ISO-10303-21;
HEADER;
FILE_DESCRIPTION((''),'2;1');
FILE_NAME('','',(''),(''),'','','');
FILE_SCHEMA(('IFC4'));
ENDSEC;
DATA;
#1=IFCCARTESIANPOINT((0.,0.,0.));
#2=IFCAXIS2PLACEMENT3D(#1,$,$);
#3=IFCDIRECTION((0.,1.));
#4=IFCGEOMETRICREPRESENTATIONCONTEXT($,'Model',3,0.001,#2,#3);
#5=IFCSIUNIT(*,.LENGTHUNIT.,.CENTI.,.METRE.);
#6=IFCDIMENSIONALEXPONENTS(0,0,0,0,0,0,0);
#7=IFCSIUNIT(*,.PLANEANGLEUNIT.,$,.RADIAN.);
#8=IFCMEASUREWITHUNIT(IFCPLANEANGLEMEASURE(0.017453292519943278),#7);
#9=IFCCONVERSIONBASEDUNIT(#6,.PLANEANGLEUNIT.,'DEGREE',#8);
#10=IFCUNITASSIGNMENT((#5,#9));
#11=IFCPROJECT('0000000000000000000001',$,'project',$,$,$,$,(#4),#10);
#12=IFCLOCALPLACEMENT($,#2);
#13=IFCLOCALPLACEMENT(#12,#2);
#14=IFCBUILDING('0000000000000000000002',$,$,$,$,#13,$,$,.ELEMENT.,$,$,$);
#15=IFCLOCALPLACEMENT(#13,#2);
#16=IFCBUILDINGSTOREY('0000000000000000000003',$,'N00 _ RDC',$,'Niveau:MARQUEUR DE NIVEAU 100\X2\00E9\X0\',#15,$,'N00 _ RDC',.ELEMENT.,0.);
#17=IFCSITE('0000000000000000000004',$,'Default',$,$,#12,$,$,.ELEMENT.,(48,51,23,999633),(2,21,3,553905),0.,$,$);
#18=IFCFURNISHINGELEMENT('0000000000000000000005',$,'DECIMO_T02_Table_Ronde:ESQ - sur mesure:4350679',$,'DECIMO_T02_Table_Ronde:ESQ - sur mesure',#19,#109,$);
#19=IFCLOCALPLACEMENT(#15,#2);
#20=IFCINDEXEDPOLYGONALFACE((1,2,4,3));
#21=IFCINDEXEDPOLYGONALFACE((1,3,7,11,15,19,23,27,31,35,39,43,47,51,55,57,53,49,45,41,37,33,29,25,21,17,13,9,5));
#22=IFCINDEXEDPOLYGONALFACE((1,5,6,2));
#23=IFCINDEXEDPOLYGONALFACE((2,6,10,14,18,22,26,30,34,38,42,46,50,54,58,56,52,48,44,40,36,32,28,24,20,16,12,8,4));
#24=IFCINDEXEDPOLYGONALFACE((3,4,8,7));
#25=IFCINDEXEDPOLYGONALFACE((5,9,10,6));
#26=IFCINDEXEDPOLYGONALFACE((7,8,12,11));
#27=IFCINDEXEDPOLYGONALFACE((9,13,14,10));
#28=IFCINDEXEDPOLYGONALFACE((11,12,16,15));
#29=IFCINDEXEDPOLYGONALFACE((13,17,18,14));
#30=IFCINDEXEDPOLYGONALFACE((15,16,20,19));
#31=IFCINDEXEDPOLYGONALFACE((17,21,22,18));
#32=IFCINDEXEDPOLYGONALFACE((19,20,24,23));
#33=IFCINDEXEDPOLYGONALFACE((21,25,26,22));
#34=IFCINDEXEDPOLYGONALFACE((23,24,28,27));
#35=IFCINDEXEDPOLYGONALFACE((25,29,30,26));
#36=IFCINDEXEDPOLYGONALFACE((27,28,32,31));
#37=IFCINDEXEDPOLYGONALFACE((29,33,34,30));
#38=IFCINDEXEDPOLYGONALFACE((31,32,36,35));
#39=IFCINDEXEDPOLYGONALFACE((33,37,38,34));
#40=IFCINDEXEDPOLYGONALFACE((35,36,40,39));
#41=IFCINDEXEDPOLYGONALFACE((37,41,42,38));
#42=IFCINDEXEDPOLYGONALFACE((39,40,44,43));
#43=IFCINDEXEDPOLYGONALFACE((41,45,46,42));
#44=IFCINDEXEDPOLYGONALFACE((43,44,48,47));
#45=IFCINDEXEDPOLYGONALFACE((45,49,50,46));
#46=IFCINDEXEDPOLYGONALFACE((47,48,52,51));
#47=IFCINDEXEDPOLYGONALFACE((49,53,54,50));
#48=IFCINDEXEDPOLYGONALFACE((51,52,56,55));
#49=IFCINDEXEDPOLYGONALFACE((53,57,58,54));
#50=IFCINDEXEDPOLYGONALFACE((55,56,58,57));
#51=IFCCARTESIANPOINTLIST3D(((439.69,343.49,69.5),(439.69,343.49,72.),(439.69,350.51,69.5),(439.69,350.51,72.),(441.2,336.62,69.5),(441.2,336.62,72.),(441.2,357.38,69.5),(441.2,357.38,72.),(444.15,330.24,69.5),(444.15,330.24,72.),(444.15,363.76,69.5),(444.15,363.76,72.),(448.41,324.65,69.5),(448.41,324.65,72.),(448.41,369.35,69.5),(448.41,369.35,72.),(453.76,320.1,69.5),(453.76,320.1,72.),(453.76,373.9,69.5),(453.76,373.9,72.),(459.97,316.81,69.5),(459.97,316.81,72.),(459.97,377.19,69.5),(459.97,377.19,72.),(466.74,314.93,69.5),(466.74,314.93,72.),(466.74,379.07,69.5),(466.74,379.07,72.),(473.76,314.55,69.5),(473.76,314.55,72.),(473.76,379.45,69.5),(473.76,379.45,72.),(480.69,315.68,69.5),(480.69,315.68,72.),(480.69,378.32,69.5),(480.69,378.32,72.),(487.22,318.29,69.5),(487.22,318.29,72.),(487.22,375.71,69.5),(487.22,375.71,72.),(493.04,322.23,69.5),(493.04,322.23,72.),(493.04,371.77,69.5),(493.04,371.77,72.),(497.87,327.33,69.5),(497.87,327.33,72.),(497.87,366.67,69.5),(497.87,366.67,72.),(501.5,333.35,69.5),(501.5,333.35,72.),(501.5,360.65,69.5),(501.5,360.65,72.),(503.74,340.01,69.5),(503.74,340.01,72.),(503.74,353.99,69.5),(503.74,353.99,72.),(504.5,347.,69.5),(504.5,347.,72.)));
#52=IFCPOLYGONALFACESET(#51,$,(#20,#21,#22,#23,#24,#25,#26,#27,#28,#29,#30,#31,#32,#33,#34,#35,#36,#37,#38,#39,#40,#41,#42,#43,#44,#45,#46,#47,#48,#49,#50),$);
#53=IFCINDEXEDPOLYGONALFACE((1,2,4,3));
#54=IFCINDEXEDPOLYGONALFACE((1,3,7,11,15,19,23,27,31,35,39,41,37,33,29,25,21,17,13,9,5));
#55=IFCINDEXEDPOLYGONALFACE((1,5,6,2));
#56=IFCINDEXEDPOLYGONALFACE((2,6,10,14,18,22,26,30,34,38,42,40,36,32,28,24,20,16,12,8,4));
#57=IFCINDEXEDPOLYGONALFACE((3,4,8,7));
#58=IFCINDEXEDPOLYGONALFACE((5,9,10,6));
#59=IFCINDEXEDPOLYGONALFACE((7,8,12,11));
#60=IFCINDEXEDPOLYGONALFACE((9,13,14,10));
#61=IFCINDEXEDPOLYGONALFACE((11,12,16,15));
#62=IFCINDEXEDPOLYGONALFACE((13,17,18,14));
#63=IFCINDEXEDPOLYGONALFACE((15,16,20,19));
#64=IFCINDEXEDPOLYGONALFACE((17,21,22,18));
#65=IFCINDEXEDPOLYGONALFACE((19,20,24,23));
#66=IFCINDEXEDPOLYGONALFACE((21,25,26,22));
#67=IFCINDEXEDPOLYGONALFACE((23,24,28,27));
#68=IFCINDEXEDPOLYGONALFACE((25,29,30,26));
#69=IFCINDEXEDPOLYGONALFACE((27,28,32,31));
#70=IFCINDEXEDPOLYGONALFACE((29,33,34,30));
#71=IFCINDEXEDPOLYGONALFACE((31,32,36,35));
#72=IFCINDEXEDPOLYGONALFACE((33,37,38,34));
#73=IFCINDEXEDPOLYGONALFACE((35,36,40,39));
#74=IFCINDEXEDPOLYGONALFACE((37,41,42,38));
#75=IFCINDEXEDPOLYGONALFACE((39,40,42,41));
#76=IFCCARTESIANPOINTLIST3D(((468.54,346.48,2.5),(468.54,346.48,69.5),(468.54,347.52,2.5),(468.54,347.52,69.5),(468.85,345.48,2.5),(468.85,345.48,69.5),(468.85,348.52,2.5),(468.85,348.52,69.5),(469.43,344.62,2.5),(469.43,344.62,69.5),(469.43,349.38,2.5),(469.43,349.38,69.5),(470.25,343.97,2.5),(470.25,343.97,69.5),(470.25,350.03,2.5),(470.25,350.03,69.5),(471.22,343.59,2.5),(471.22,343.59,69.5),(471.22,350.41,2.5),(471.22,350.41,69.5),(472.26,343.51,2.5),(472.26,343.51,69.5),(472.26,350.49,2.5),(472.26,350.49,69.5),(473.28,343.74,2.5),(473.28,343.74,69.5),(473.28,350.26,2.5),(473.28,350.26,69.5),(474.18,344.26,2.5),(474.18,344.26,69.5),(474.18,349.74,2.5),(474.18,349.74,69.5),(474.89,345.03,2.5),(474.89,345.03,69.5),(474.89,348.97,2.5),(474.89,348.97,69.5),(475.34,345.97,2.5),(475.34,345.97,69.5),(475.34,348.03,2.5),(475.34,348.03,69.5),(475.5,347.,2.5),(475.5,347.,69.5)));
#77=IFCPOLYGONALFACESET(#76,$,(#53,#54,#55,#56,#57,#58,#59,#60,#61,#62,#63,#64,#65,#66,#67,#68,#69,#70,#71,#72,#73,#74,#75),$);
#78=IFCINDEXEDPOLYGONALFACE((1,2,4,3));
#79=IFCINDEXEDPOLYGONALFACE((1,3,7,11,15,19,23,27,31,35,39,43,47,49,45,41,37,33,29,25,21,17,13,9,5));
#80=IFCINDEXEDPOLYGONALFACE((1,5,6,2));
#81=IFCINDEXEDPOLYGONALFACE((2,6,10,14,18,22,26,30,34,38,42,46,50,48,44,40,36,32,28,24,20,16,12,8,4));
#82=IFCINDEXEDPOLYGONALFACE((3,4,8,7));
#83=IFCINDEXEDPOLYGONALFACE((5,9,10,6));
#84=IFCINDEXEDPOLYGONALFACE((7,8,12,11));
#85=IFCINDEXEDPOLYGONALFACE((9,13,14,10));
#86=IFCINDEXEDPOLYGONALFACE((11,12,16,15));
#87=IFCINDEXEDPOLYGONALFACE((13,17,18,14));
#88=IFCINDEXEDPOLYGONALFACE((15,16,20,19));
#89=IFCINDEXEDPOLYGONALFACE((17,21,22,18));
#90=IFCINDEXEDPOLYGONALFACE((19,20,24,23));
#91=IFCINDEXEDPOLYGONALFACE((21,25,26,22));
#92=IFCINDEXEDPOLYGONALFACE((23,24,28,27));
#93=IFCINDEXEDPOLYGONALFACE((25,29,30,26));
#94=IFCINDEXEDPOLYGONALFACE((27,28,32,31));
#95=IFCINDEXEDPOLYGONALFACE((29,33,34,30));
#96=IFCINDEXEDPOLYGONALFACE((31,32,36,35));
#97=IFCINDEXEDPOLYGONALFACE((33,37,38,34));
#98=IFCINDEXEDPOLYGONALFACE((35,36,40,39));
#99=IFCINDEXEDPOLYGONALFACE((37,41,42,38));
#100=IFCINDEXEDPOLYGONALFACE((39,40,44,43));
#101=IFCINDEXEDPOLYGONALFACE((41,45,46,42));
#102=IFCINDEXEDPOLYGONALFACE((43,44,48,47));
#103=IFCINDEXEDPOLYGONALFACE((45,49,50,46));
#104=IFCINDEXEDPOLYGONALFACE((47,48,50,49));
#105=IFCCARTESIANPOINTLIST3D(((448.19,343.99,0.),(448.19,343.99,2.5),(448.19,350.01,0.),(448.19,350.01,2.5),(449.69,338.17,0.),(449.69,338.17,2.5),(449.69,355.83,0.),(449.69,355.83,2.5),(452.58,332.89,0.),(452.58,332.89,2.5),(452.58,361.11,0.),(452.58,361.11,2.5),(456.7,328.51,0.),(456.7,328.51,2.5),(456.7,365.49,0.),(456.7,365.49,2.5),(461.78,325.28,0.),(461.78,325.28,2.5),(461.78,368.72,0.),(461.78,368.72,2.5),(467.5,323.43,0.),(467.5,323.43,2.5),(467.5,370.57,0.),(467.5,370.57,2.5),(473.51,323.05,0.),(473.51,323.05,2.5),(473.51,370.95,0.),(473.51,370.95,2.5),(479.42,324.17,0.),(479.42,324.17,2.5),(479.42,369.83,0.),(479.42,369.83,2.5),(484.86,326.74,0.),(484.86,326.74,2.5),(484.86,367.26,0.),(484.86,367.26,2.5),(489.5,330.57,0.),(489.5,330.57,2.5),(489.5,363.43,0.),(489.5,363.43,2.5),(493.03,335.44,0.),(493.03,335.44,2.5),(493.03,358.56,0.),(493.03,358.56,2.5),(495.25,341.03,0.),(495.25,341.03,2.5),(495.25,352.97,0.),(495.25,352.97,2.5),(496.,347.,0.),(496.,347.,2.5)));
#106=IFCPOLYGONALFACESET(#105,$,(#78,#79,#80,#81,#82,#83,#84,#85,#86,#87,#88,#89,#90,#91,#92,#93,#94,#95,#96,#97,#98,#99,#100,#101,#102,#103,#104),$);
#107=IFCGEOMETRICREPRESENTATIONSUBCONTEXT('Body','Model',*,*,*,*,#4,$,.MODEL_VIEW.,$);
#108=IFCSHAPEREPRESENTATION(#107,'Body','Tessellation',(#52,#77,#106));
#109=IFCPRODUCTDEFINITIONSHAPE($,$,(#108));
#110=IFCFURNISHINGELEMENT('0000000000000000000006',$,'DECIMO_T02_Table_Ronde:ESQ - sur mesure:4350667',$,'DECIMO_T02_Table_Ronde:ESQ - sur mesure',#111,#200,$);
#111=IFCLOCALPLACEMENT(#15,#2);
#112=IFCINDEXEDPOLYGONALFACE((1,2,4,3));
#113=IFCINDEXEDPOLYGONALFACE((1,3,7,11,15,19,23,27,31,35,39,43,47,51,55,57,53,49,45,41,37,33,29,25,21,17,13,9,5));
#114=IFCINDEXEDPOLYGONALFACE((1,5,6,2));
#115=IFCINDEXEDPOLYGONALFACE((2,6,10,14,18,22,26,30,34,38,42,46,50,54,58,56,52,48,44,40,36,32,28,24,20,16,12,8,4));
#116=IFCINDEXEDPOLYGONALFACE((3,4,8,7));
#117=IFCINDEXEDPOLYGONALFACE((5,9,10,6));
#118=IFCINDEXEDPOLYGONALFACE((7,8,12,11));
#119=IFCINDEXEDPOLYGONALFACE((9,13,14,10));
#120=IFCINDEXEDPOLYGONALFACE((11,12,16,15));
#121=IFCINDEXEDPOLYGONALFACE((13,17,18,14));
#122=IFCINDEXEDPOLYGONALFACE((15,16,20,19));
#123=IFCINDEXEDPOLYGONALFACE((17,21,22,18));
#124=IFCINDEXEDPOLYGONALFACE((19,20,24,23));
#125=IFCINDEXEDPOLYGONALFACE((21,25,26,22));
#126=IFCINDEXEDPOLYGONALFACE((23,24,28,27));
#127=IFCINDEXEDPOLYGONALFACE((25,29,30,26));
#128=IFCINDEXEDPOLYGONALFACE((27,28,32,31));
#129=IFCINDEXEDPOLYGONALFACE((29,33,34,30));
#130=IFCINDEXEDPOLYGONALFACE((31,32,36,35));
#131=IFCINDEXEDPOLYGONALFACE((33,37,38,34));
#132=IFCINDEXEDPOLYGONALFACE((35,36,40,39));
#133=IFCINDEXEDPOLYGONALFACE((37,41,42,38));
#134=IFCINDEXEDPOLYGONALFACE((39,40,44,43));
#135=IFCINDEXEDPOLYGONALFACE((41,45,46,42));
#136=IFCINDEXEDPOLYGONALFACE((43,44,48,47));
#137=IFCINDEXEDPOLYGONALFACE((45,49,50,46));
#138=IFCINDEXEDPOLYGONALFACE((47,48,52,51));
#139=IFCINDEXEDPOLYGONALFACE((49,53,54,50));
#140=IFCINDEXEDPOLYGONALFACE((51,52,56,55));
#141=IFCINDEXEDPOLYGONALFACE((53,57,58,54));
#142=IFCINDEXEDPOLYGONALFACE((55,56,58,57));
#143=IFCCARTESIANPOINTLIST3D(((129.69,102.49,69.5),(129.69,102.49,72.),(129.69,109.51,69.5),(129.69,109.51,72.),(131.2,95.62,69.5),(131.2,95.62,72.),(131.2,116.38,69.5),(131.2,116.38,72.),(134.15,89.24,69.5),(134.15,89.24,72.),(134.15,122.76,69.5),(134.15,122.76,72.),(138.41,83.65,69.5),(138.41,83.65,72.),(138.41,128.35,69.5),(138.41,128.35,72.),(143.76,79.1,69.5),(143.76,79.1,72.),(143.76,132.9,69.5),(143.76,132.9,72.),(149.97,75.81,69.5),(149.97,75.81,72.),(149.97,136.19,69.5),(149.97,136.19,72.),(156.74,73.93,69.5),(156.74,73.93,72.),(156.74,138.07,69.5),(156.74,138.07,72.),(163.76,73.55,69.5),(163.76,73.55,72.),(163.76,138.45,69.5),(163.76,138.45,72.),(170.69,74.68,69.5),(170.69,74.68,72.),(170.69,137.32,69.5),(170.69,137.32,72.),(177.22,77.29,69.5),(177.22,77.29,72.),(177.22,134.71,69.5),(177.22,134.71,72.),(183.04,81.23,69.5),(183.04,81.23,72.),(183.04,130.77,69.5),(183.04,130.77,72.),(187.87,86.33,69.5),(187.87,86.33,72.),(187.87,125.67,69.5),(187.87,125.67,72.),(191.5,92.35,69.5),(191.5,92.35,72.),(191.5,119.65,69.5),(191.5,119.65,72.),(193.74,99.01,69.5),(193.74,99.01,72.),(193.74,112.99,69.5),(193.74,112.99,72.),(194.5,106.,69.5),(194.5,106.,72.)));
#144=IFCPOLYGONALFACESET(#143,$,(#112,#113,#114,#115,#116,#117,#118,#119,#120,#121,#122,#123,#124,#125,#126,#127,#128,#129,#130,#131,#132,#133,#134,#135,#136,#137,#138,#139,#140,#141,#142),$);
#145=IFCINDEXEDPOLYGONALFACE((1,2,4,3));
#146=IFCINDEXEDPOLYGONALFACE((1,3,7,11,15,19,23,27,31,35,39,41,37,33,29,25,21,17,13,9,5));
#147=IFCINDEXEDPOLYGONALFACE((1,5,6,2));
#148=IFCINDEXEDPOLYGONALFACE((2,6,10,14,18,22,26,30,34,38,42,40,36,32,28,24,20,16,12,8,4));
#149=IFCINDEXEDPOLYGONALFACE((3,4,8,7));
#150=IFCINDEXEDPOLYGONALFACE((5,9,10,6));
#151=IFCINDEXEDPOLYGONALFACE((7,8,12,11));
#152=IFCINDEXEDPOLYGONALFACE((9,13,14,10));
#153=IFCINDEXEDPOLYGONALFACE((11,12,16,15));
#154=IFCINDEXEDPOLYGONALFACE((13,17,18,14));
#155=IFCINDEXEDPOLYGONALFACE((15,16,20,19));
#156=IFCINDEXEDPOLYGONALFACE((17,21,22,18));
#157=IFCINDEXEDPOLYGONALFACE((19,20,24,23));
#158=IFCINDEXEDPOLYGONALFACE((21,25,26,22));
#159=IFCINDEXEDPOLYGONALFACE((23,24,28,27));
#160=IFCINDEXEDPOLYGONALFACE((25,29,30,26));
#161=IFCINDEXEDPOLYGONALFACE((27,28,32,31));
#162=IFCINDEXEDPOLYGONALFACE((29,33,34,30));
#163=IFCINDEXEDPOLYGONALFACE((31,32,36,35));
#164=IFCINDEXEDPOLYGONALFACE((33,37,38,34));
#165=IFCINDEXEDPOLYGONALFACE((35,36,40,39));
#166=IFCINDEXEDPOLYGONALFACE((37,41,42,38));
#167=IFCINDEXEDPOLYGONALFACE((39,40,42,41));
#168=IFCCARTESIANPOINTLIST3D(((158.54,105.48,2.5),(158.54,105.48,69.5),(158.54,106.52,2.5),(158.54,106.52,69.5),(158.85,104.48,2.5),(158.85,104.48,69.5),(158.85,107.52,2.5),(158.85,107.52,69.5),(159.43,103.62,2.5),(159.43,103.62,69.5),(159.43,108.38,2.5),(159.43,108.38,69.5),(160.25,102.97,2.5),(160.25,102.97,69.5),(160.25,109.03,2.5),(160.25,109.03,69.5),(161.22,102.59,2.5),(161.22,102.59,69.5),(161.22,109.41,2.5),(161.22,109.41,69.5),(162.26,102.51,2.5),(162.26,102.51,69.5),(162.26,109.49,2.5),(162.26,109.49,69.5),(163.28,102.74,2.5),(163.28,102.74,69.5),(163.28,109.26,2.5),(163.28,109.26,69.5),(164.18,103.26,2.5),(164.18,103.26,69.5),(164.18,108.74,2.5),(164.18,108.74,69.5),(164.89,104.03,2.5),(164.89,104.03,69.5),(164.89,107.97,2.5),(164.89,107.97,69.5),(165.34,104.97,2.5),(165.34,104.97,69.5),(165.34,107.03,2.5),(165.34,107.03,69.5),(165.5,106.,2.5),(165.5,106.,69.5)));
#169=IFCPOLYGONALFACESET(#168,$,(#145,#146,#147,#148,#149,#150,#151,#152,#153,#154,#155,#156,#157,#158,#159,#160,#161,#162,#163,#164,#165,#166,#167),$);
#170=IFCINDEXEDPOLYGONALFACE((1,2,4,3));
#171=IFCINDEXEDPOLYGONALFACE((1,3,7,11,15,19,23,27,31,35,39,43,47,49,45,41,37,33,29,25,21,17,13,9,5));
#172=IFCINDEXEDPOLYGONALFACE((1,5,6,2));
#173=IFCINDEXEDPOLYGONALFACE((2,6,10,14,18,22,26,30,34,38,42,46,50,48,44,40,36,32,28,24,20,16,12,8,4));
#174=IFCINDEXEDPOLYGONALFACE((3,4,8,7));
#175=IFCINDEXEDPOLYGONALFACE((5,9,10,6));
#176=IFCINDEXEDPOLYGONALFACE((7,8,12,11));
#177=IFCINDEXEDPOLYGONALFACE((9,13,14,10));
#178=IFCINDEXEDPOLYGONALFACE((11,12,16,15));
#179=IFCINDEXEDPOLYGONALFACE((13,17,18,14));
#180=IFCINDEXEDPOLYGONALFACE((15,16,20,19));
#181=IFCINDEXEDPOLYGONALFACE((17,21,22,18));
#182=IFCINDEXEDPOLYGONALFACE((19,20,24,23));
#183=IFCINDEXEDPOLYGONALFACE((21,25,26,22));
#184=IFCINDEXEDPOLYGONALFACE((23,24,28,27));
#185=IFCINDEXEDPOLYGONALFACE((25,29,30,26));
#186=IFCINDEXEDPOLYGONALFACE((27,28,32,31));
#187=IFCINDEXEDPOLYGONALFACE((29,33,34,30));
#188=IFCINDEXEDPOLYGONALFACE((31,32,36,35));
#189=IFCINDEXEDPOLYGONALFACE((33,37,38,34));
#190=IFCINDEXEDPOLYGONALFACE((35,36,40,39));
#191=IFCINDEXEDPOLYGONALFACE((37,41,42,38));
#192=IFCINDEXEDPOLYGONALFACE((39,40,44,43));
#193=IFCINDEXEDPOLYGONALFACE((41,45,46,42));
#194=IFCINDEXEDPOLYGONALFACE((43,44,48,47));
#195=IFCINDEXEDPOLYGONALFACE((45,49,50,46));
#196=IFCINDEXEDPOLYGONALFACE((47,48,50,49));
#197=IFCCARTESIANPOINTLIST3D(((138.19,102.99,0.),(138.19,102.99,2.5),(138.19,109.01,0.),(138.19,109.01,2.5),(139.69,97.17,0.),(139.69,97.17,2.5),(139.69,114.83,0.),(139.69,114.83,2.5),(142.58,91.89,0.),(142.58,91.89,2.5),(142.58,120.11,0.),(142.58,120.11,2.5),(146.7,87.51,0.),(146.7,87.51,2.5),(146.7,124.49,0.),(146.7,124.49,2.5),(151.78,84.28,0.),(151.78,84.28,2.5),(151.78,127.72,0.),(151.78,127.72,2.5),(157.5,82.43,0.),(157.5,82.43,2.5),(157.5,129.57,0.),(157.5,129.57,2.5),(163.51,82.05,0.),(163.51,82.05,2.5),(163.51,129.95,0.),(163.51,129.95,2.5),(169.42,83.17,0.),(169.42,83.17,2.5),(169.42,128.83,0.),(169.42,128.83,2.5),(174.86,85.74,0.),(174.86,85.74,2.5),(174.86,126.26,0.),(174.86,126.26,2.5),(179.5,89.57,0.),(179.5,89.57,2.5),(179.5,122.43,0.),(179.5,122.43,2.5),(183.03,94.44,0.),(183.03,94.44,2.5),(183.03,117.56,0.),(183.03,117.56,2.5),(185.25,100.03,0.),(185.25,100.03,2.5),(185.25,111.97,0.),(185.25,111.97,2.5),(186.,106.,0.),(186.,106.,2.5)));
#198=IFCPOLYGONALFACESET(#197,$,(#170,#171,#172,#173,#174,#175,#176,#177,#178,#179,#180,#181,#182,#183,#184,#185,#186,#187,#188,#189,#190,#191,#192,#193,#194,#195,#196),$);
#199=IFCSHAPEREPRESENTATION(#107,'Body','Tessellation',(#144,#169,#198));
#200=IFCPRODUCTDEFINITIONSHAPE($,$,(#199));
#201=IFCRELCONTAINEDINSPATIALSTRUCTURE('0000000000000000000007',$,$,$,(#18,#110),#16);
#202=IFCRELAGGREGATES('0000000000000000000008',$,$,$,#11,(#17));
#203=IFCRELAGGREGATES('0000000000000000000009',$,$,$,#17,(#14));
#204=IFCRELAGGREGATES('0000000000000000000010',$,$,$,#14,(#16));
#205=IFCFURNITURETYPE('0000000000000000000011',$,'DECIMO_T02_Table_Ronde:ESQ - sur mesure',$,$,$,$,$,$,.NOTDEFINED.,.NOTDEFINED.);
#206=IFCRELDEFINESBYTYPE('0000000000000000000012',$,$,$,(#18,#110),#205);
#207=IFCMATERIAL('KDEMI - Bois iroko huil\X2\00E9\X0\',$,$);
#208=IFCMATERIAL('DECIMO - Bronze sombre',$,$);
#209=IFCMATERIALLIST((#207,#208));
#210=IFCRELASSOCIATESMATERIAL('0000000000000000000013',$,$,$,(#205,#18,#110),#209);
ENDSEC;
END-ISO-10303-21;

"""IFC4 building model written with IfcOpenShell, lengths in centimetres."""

from ifc_helpers import new_model, entity, si_unit, converted_unit, direction, frame, frame_2d, origin, place, context, subcontext, project, spatial, circle, extrude, source, transform, mapped, material, material_list, type_object, type_shapes, element, save


model = new_model("IFC4")

# Units and contexts
model_context = context("Model", 3, precision=0.001, world=origin(), true_north=direction((0.0, 1.0)))
body_context = subcontext(model_context, "Body", "Model", "MODEL_VIEW")
ifc_project = project(units=[si_unit("LENGTHUNIT", "METRE", prefix="CENTI"), converted_unit("PLANEANGLEUNIT", "DEGREE", entity("IfcPlaneAngleMeasure", 0.017453292519943278), si_unit("PLANEANGLEUNIT", "RADIAN"), dimensions=[0, 0, 0, 0, 0, 0, 0])], contexts=[model_context])

# Site, building, storey
site_placement = place(None, origin())
site = spatial("IfcSite", under=ifc_project, at=site_placement, Name="Default", CompositionType="ELEMENT", RefLatitude=(48, 51, 23, 999633), RefLongitude=(2, 21, 3, 553905), RefElevation=0.0)
building_placement = place(site_placement, origin())
building = spatial("IfcBuilding", under=site, at=building_placement, CompositionType="ELEMENT")
storey_placement = place(building_placement, origin())
storey = spatial("IfcBuildingStorey", under=building, at=storey_placement, Name="N00 _ RDC", ObjectType="Niveau:MARQUEUR DE NIVEAU 100é", LongName="N00 _ RDC", CompositionType="ELEMENT", Elevation=0.0)

# Furnishing elements
ifc_material_1 = material(Name="KDEMI - Bois iroko huilé")
ifc_material_2 = material(Name="DECIMO - Bronze sombre")
ifc_material_list_1 = material_list([ifc_material_1, ifc_material_2])
furniture_type_1 = type_object("IfcFurnitureType", Name="DECIMO_T02_Table_Ronde:ESQ - sur mesure", AssemblyPlace="NOTDEFINED", material=ifc_material_list_1)
shared_shape_1 = source(origin(), body_context, "Body", "SweptSolid", [
    extrude(circle(Radius=32.5, at=frame_2d((0.0, 0.0), x_axis=(1.0, 0.0))), frame((0.0, 0.0, 69.5)), (0.0, 0.0, 1.0), 2.5),
    extrude(circle(Radius=3.5, at=frame_2d((0.0, 0.0), x_axis=(1.0, 0.0))), frame((0.0, 0.0, 2.5)), (0.0, 0.0, 1.0), 67.0),
    extrude(circle(Radius=24.0, at=frame_2d((0.0, 0.0), x_axis=(1.0, 0.0))), origin(), (0.0, 0.0, 1.0), 2.5),
])
type_shapes(furniture_type_1, [shared_shape_1])
for number, where, z_axis, x_axis, name in (
    (1, (472.0, 347.0, 0.0), (0.0, 0.0, 1.0), (1.0, 0.0, 0.0), "DECIMO_T02_Table_Ronde:ESQ - sur mesure:4350679"),
):
    element("IfcFurnishingElement", number, at=place(storey_placement, frame(where, z_axis=z_axis, x_axis=x_axis)), inside=storey, type_object=furniture_type_1, material=ifc_material_list_1, Name=name, ObjectType="DECIMO_T02_Table_Ronde:ESQ - sur mesure", context=body_context, shape_type="MappedRepresentation", body=[
        mapped(shared_shape_1, transform((0.0, 0.0, 0.0), scale=1.0)),
    ])
for number, where, name in (
    (2, (162.0, 106.0, 0.0), "DECIMO_T02_Table_Ronde:ESQ - sur mesure:4350667"),
):
    element("IfcFurnishingElement", number, at=place(storey_placement, frame(where)), inside=storey, type_object=furniture_type_1, material=ifc_material_list_1, Name=name, ObjectType="DECIMO_T02_Table_Ronde:ESQ - sur mesure", context=body_context, shape_type="MappedRepresentation", body=[
        mapped(shared_shape_1, transform((0.0, 0.0, 0.0), scale=1.0)),
    ])

save(model, "model.ifc")
